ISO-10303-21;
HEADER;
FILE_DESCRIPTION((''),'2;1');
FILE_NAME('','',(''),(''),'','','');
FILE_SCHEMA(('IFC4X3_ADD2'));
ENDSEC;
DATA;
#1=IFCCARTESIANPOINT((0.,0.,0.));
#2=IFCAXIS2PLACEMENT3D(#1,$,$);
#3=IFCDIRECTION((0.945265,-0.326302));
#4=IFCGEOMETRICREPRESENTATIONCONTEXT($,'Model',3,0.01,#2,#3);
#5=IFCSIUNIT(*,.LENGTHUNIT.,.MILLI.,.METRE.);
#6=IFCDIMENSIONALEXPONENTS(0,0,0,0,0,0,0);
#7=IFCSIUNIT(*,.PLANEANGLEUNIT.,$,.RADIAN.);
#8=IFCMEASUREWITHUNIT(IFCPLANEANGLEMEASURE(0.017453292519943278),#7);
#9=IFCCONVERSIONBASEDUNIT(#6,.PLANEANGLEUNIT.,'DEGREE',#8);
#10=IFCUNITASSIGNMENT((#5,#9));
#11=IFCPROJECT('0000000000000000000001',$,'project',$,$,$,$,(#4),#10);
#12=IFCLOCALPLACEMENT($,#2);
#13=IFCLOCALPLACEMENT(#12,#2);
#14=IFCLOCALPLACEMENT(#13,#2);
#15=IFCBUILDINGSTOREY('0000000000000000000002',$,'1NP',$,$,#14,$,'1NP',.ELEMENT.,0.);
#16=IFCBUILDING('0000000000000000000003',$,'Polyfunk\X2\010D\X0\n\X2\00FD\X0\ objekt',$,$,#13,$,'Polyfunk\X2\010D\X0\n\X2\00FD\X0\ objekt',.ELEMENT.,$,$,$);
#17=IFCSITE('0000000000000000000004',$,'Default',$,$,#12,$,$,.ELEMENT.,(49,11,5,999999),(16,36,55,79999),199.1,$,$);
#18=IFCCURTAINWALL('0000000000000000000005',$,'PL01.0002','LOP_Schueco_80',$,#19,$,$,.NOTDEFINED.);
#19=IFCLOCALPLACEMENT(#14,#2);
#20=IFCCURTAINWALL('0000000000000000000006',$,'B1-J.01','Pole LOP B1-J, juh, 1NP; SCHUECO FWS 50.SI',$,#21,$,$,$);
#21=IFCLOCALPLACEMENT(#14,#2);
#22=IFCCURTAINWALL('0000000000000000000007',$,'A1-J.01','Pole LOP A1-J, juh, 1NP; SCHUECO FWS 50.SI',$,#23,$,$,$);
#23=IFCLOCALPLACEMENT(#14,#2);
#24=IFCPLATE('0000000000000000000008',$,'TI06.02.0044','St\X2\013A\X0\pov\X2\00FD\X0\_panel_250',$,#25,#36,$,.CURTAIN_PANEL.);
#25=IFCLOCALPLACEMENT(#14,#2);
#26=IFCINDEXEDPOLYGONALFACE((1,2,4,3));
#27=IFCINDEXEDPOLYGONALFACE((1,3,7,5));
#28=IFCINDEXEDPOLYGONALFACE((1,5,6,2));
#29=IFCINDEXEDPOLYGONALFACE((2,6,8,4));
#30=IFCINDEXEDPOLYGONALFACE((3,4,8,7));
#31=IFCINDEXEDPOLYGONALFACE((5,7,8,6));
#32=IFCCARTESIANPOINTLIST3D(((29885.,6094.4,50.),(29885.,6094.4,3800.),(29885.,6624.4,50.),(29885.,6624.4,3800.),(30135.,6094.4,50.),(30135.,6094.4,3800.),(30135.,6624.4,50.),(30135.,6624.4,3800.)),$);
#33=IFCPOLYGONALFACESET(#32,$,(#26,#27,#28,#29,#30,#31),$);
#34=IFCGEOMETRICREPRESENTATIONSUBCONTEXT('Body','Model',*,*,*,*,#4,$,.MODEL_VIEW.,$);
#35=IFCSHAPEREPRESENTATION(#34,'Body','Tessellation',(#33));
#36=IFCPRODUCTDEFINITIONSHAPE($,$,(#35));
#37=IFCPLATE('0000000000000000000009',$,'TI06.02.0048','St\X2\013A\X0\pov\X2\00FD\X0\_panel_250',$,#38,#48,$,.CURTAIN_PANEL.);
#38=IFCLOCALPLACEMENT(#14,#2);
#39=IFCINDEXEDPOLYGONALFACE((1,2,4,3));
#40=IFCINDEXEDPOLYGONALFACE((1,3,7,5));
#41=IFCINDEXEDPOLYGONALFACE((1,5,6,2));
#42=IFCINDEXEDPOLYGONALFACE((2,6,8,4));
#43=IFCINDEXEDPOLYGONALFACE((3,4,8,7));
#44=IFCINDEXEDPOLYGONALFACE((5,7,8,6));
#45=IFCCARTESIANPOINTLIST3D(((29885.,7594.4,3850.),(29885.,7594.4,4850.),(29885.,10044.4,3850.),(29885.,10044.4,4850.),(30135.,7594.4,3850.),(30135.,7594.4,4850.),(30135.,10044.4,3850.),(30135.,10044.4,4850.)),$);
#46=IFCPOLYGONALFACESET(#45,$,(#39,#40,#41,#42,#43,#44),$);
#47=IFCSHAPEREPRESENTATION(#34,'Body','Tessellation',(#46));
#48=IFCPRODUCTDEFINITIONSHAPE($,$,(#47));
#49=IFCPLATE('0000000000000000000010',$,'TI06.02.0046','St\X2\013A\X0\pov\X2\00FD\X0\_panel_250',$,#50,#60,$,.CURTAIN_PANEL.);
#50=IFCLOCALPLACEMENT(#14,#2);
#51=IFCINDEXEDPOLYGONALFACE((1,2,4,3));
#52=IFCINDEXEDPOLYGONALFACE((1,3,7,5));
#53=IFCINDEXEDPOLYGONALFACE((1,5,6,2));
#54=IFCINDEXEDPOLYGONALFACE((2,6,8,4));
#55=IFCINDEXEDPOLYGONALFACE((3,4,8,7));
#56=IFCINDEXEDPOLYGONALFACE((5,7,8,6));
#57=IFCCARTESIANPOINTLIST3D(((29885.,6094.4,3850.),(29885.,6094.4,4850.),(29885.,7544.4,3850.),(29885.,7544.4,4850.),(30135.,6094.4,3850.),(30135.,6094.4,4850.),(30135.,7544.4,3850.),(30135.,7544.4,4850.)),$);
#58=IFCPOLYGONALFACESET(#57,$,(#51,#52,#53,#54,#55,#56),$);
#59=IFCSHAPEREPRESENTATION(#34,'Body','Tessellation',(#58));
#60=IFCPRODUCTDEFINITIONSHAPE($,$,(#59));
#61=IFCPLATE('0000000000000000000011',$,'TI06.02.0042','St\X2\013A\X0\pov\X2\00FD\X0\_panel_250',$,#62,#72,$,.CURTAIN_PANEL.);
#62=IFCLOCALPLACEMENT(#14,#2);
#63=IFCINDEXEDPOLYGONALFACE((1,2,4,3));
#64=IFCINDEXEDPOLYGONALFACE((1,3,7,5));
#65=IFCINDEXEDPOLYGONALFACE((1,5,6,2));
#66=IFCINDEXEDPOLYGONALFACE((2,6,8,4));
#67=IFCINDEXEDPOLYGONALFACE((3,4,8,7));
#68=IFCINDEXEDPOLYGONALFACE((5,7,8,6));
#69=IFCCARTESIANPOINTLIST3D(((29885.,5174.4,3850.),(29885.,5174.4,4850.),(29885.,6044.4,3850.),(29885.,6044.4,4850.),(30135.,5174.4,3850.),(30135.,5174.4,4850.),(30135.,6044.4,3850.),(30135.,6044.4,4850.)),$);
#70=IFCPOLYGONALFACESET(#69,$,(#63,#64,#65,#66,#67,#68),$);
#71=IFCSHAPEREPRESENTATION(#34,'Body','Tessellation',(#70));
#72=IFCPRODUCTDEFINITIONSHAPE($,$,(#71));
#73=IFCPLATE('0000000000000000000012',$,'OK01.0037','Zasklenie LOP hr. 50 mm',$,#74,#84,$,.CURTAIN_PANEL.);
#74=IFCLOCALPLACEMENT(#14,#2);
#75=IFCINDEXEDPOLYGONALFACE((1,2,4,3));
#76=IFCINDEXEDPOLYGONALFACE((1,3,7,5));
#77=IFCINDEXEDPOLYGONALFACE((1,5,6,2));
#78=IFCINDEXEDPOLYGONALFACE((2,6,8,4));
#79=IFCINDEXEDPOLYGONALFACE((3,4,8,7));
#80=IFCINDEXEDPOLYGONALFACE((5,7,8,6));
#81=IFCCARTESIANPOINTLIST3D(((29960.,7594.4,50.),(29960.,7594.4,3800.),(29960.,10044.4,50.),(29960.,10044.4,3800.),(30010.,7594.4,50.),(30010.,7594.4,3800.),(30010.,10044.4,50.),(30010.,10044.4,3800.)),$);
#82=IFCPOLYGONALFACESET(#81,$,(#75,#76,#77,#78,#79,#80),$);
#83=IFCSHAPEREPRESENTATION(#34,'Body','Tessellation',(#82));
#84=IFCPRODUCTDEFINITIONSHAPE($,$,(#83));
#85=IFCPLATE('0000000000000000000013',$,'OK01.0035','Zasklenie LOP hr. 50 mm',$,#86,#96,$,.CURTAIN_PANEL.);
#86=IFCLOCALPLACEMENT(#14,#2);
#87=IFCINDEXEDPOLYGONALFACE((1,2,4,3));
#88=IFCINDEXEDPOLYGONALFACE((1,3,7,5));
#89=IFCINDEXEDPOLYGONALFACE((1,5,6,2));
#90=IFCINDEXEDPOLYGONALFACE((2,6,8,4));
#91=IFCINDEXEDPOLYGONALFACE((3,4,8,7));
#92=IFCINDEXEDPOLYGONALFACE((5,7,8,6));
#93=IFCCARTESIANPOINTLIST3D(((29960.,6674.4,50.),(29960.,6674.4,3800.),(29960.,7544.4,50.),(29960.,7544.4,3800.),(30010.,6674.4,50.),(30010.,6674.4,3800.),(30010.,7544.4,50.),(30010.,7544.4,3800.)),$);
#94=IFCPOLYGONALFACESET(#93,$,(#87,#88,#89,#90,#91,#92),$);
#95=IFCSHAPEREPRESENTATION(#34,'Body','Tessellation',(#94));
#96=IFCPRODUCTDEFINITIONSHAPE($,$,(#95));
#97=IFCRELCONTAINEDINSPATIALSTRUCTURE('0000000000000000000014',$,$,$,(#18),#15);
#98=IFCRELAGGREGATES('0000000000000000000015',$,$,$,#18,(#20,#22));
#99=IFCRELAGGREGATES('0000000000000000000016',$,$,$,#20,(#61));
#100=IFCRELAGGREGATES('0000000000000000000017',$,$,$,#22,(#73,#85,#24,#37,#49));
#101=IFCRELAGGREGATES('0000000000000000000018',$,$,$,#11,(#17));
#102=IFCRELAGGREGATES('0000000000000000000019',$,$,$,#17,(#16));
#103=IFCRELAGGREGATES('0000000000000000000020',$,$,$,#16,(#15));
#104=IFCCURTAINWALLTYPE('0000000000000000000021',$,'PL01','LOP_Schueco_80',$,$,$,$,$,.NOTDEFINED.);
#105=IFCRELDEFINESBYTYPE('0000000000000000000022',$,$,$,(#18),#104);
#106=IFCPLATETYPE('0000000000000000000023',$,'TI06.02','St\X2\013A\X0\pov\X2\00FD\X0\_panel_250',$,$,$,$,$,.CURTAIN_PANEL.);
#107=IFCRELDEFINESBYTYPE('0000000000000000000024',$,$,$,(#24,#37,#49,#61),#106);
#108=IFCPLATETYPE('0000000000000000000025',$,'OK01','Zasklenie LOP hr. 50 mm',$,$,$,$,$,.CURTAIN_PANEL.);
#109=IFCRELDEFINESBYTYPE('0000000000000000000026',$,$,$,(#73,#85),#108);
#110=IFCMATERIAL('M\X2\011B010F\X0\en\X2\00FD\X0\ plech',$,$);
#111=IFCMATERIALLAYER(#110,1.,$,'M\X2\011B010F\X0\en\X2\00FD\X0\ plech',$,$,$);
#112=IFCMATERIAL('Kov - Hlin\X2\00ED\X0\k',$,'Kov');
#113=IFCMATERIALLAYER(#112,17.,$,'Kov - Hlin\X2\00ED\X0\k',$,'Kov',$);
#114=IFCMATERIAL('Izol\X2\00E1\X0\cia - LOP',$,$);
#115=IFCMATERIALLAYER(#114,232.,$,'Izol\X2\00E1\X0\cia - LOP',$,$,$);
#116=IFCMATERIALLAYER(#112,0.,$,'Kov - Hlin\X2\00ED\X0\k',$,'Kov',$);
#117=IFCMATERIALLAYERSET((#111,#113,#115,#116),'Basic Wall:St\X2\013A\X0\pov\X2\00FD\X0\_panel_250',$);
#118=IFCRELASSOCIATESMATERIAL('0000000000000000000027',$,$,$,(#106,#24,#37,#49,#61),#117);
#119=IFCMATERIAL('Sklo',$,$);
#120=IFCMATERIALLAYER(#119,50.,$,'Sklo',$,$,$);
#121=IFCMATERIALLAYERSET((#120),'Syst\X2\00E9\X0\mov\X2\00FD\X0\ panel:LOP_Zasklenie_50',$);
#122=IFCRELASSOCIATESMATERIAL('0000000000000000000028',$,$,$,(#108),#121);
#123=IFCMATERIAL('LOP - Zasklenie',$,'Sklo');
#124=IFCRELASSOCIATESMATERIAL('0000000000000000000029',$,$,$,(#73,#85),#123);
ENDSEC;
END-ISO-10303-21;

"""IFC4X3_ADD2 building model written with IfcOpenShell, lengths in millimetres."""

from ifc_helpers import new_model, entity, si_unit, converted_unit, direction, frame, frame_2d, origin, place, context, subcontext, project, spatial, rectangle, extrude, source, transform, mapped, material, layer, layer_set, layer_usage, type_object, type_shapes, element, aggregate, save


model = new_model("IFC4X3_ADD2")

# Units and contexts
model_context = context("Model", 3, precision=0.01, world=origin(), true_north=direction((0.945265, -0.326302)))
body_context = subcontext(model_context, "Body", "Model", "MODEL_VIEW")
ifc_project = project(units=[si_unit("LENGTHUNIT", "METRE", prefix="MILLI"), converted_unit("PLANEANGLEUNIT", "DEGREE", entity("IfcPlaneAngleMeasure", 0.017453292519943278), si_unit("PLANEANGLEUNIT", "RADIAN"), dimensions=[0, 0, 0, 0, 0, 0, 0])], contexts=[model_context])

# Site, building, storey
site_placement = place(None, origin())
site = spatial("IfcSite", under=ifc_project, at=site_placement, Name="Default", CompositionType="ELEMENT", RefLatitude=(49, 11, 5, 999999), RefLongitude=(16, 36, 55, 79999), RefElevation=199.1)
building_placement = place(site_placement, origin())
building = spatial("IfcBuilding", under=site, at=building_placement, Name="Polyfunkčný objekt", LongName="Polyfunkčný objekt", CompositionType="ELEMENT")
storey_placement = place(building_placement, origin())
storey = spatial("IfcBuildingStorey", under=building, at=storey_placement, Name="1NP", LongName="1NP", CompositionType="ELEMENT", Elevation=0.0)

# Curtain walls, plates
curtain_wall_type = type_object("IfcCurtainWallType", Name="PL01", Description="LOP_Schueco_80", PredefinedType="NOTDEFINED")
curtain_wall_1_placement = place(storey_placement, origin())
curtain_wall_1 = element("IfcCurtainWall", 1, at=curtain_wall_1_placement, inside=storey, type_object=curtain_wall_type, Name="PL01.0002", Description="LOP_Schueco_80", PredefinedType="NOTDEFINED")
curtain_wall_2 = element("IfcCurtainWall", 2, Name="B1-J.01", Description="Pole LOP B1-J, juh, 1NP; SCHUECO FWS 50.SI")
curtain_wall_3 = element("IfcCurtainWall", 3, Name="A1-J.01", Description="Pole LOP A1-J, juh, 1NP; SCHUECO FWS 50.SI")
aggregate(curtain_wall_1, [curtain_wall_2, curtain_wall_3])
ifc_material_1 = material(Name="Měďený plech")
ifc_layer_1 = layer(ifc_material_1, 1.0, Name="Měďený plech")
ifc_material_2 = material(Name="Kov - Hliník", Category="Kov")
ifc_layer_2 = layer(ifc_material_2, 17.0, Name="Kov - Hliník", Category="Kov")
ifc_material_3 = material(Name="Izolácia - LOP")
ifc_layer_3 = layer(ifc_material_3, 232.0, Name="Izolácia - LOP")
ifc_layer_4 = layer(ifc_material_2, 0.0, Name="Kov - Hliník", Category="Kov")
ifc_layer_set_1 = layer_set([ifc_layer_1, ifc_layer_2, ifc_layer_3, ifc_layer_4], Name="Basic Wall:Stĺpový_panel_250")
ifc_layer_usage_1 = layer_usage(ifc_layer_set_1, "AXIS2", "POSITIVE", -125.0)
plate_type_1 = type_object("IfcPlateType", Name="TI06.02", Description="Stĺpový_panel_250", PredefinedType="CURTAIN_PANEL", material=ifc_layer_set_1)
plate_1_placement = place(storey_placement, frame((30010.0, 6624.4, 50.0), z_axis=(0.0, 0.0, 1.0), x_axis=(0.0, -1.0, 0.0)))
plate_1 = element("IfcPlate", 4, at=plate_1_placement, type_object=plate_type_1, material=ifc_layer_usage_1, Name="TI06.02.0044", Description="Stĺpový_panel_250", PredefinedType="CURTAIN_PANEL", context=body_context, shape_type="SweptSolid", body=[
    extrude(rectangle(XDim=250.0, YDim=530.0, at=frame_2d((0.0, 0.0), x_axis=(1.0, 0.0))), frame((265.0, 0.0, 0.0), z_axis=(0.0, 0.0, 1.0), x_axis=(0.0, 1.0, 0.0)), (0.0, 0.0, 1.0), 3750.0),
])
ifc_layer_usage_2 = layer_usage(ifc_layer_set_1, "AXIS2", "POSITIVE", -125.0)
plate_2_placement = place(storey_placement, frame((30010.0, 10044.4, 3850.0), z_axis=(0.0, 0.0, 1.0), x_axis=(0.0, -1.0, 0.0)))
plate_2 = element("IfcPlate", 5, at=plate_2_placement, type_object=plate_type_1, material=ifc_layer_usage_2, Name="TI06.02.0048", Description="Stĺpový_panel_250", PredefinedType="CURTAIN_PANEL", context=body_context, shape_type="SweptSolid", body=[
    extrude(rectangle(XDim=250.0, YDim=2450.0, at=frame_2d((0.0, 0.0), x_axis=(1.0, 0.0))), frame((1225.0, 0.0, 0.0), z_axis=(0.0, 0.0, 1.0), x_axis=(0.0, 1.0, 0.0)), (0.0, 0.0, 1.0), 1000.0),
])
ifc_layer_usage_3 = layer_usage(ifc_layer_set_1, "AXIS2", "POSITIVE", -125.0)
plate_3_placement = place(storey_placement, frame((30010.0, 7544.4, 3850.0), z_axis=(0.0, 0.0, 1.0), x_axis=(0.0, -1.0, 0.0)))
plate_3 = element("IfcPlate", 6, at=plate_3_placement, type_object=plate_type_1, material=ifc_layer_usage_3, Name="TI06.02.0046", Description="Stĺpový_panel_250", PredefinedType="CURTAIN_PANEL", context=body_context, shape_type="SweptSolid", body=[
    extrude(rectangle(XDim=250.0, YDim=1450.0, at=frame_2d((0.0, 0.0), x_axis=(1.0, 0.0))), frame((725.0, 0.0, 0.0), z_axis=(0.0, 0.0, 1.0), x_axis=(0.0, 1.0, 0.0)), (0.0, 0.0, 1.0), 1000.0),
])
ifc_layer_usage_4 = layer_usage(ifc_layer_set_1, "AXIS2", "POSITIVE", -125.0)
plate_4_placement = place(storey_placement, frame((30010.0, 6044.4, 3850.0), z_axis=(0.0, 0.0, 1.0), x_axis=(0.0, -1.0, 0.0)))
plate_4 = element("IfcPlate", 7, at=plate_4_placement, type_object=plate_type_1, material=ifc_layer_usage_4, Name="TI06.02.0042", Description="Stĺpový_panel_250", PredefinedType="CURTAIN_PANEL", context=body_context, shape_type="SweptSolid", body=[
    extrude(rectangle(XDim=250.0, YDim=870.0, at=frame_2d((0.0, 0.0), x_axis=(1.0, 0.0))), frame((435.0, 0.0, 0.0), z_axis=(0.0, 0.0, 1.0), x_axis=(0.0, 1.0, 0.0)), (0.0, 0.0, 1.0), 1000.0),
])
aggregate(curtain_wall_2, [plate_4])
ifc_material_4 = material(Name="LOP - Zasklenie", Category="Sklo")
ifc_material_5 = material(Name="Sklo")
ifc_layer_5 = layer(ifc_material_5, 50.0, Name="Sklo")
ifc_layer_set_2 = layer_set([ifc_layer_5], Name="Systémový panel:LOP_Zasklenie_50")
plate_type_2 = type_object("IfcPlateType", Name="OK01", Description="Zasklenie LOP hr. 50 mm", PredefinedType="CURTAIN_PANEL", material=ifc_layer_set_2)
shared_shape_1 = source(origin(), body_context, "Body", "SweptSolid", [
    extrude(rectangle(XDim=3750.0, YDim=2450.0, at=frame_2d((-141.7, 0.0), x_axis=(1.0, 0.0))), frame((0.0, -50.0, 2016.7), z_axis=(0.0, 1.0, 0.0), x_axis=(0.0, 0.0, 1.0)), (0.0, 0.0, 1.0), 50.0),
])
plate_5_placement = place(curtain_wall_1_placement, frame((30010.0, 8819.4, 50.0), z_axis=(0.0, 0.0, 1.0), x_axis=(0.0, -1.0, 0.0)))
plate_5 = element("IfcPlate", 8, at=plate_5_placement, type_object=plate_type_2, material=ifc_material_4, Name="OK01.0037", Description="Zasklenie LOP hr. 50 mm", PredefinedType="CURTAIN_PANEL", context=body_context, shape_type="MappedRepresentation", body=[
    mapped(shared_shape_1, transform((0.0, 0.0, 0.0), scale=1.0)),
])
shared_shape_2 = source(origin(), body_context, "Body", "SweptSolid", [
    extrude(rectangle(XDim=3750.0, YDim=870.0, at=frame_2d((-141.7, 0.0), x_axis=(1.0, 0.0))), frame((0.0, -50.0, 2016.7), z_axis=(0.0, 1.0, 0.0), x_axis=(0.0, 0.0, 1.0)), (0.0, 0.0, 1.0), 50.0),
])
type_shapes(plate_type_2, [shared_shape_1, shared_shape_2])
plate_6_placement = place(curtain_wall_1_placement, frame((30010.0, 7109.4, 50.0), z_axis=(0.0, 0.0, 1.0), x_axis=(0.0, -1.0, 0.0)))
plate_6 = element("IfcPlate", 9, at=plate_6_placement, type_object=plate_type_2, material=ifc_material_4, Name="OK01.0035", Description="Zasklenie LOP hr. 50 mm", PredefinedType="CURTAIN_PANEL", context=body_context, shape_type="MappedRepresentation", body=[
    mapped(shared_shape_2, transform((0.0, 0.0, 0.0), scale=1.0)),
])
aggregate(curtain_wall_3, [plate_5, plate_6, plate_1, plate_2, plate_3])

save(model, "model.ifc")
